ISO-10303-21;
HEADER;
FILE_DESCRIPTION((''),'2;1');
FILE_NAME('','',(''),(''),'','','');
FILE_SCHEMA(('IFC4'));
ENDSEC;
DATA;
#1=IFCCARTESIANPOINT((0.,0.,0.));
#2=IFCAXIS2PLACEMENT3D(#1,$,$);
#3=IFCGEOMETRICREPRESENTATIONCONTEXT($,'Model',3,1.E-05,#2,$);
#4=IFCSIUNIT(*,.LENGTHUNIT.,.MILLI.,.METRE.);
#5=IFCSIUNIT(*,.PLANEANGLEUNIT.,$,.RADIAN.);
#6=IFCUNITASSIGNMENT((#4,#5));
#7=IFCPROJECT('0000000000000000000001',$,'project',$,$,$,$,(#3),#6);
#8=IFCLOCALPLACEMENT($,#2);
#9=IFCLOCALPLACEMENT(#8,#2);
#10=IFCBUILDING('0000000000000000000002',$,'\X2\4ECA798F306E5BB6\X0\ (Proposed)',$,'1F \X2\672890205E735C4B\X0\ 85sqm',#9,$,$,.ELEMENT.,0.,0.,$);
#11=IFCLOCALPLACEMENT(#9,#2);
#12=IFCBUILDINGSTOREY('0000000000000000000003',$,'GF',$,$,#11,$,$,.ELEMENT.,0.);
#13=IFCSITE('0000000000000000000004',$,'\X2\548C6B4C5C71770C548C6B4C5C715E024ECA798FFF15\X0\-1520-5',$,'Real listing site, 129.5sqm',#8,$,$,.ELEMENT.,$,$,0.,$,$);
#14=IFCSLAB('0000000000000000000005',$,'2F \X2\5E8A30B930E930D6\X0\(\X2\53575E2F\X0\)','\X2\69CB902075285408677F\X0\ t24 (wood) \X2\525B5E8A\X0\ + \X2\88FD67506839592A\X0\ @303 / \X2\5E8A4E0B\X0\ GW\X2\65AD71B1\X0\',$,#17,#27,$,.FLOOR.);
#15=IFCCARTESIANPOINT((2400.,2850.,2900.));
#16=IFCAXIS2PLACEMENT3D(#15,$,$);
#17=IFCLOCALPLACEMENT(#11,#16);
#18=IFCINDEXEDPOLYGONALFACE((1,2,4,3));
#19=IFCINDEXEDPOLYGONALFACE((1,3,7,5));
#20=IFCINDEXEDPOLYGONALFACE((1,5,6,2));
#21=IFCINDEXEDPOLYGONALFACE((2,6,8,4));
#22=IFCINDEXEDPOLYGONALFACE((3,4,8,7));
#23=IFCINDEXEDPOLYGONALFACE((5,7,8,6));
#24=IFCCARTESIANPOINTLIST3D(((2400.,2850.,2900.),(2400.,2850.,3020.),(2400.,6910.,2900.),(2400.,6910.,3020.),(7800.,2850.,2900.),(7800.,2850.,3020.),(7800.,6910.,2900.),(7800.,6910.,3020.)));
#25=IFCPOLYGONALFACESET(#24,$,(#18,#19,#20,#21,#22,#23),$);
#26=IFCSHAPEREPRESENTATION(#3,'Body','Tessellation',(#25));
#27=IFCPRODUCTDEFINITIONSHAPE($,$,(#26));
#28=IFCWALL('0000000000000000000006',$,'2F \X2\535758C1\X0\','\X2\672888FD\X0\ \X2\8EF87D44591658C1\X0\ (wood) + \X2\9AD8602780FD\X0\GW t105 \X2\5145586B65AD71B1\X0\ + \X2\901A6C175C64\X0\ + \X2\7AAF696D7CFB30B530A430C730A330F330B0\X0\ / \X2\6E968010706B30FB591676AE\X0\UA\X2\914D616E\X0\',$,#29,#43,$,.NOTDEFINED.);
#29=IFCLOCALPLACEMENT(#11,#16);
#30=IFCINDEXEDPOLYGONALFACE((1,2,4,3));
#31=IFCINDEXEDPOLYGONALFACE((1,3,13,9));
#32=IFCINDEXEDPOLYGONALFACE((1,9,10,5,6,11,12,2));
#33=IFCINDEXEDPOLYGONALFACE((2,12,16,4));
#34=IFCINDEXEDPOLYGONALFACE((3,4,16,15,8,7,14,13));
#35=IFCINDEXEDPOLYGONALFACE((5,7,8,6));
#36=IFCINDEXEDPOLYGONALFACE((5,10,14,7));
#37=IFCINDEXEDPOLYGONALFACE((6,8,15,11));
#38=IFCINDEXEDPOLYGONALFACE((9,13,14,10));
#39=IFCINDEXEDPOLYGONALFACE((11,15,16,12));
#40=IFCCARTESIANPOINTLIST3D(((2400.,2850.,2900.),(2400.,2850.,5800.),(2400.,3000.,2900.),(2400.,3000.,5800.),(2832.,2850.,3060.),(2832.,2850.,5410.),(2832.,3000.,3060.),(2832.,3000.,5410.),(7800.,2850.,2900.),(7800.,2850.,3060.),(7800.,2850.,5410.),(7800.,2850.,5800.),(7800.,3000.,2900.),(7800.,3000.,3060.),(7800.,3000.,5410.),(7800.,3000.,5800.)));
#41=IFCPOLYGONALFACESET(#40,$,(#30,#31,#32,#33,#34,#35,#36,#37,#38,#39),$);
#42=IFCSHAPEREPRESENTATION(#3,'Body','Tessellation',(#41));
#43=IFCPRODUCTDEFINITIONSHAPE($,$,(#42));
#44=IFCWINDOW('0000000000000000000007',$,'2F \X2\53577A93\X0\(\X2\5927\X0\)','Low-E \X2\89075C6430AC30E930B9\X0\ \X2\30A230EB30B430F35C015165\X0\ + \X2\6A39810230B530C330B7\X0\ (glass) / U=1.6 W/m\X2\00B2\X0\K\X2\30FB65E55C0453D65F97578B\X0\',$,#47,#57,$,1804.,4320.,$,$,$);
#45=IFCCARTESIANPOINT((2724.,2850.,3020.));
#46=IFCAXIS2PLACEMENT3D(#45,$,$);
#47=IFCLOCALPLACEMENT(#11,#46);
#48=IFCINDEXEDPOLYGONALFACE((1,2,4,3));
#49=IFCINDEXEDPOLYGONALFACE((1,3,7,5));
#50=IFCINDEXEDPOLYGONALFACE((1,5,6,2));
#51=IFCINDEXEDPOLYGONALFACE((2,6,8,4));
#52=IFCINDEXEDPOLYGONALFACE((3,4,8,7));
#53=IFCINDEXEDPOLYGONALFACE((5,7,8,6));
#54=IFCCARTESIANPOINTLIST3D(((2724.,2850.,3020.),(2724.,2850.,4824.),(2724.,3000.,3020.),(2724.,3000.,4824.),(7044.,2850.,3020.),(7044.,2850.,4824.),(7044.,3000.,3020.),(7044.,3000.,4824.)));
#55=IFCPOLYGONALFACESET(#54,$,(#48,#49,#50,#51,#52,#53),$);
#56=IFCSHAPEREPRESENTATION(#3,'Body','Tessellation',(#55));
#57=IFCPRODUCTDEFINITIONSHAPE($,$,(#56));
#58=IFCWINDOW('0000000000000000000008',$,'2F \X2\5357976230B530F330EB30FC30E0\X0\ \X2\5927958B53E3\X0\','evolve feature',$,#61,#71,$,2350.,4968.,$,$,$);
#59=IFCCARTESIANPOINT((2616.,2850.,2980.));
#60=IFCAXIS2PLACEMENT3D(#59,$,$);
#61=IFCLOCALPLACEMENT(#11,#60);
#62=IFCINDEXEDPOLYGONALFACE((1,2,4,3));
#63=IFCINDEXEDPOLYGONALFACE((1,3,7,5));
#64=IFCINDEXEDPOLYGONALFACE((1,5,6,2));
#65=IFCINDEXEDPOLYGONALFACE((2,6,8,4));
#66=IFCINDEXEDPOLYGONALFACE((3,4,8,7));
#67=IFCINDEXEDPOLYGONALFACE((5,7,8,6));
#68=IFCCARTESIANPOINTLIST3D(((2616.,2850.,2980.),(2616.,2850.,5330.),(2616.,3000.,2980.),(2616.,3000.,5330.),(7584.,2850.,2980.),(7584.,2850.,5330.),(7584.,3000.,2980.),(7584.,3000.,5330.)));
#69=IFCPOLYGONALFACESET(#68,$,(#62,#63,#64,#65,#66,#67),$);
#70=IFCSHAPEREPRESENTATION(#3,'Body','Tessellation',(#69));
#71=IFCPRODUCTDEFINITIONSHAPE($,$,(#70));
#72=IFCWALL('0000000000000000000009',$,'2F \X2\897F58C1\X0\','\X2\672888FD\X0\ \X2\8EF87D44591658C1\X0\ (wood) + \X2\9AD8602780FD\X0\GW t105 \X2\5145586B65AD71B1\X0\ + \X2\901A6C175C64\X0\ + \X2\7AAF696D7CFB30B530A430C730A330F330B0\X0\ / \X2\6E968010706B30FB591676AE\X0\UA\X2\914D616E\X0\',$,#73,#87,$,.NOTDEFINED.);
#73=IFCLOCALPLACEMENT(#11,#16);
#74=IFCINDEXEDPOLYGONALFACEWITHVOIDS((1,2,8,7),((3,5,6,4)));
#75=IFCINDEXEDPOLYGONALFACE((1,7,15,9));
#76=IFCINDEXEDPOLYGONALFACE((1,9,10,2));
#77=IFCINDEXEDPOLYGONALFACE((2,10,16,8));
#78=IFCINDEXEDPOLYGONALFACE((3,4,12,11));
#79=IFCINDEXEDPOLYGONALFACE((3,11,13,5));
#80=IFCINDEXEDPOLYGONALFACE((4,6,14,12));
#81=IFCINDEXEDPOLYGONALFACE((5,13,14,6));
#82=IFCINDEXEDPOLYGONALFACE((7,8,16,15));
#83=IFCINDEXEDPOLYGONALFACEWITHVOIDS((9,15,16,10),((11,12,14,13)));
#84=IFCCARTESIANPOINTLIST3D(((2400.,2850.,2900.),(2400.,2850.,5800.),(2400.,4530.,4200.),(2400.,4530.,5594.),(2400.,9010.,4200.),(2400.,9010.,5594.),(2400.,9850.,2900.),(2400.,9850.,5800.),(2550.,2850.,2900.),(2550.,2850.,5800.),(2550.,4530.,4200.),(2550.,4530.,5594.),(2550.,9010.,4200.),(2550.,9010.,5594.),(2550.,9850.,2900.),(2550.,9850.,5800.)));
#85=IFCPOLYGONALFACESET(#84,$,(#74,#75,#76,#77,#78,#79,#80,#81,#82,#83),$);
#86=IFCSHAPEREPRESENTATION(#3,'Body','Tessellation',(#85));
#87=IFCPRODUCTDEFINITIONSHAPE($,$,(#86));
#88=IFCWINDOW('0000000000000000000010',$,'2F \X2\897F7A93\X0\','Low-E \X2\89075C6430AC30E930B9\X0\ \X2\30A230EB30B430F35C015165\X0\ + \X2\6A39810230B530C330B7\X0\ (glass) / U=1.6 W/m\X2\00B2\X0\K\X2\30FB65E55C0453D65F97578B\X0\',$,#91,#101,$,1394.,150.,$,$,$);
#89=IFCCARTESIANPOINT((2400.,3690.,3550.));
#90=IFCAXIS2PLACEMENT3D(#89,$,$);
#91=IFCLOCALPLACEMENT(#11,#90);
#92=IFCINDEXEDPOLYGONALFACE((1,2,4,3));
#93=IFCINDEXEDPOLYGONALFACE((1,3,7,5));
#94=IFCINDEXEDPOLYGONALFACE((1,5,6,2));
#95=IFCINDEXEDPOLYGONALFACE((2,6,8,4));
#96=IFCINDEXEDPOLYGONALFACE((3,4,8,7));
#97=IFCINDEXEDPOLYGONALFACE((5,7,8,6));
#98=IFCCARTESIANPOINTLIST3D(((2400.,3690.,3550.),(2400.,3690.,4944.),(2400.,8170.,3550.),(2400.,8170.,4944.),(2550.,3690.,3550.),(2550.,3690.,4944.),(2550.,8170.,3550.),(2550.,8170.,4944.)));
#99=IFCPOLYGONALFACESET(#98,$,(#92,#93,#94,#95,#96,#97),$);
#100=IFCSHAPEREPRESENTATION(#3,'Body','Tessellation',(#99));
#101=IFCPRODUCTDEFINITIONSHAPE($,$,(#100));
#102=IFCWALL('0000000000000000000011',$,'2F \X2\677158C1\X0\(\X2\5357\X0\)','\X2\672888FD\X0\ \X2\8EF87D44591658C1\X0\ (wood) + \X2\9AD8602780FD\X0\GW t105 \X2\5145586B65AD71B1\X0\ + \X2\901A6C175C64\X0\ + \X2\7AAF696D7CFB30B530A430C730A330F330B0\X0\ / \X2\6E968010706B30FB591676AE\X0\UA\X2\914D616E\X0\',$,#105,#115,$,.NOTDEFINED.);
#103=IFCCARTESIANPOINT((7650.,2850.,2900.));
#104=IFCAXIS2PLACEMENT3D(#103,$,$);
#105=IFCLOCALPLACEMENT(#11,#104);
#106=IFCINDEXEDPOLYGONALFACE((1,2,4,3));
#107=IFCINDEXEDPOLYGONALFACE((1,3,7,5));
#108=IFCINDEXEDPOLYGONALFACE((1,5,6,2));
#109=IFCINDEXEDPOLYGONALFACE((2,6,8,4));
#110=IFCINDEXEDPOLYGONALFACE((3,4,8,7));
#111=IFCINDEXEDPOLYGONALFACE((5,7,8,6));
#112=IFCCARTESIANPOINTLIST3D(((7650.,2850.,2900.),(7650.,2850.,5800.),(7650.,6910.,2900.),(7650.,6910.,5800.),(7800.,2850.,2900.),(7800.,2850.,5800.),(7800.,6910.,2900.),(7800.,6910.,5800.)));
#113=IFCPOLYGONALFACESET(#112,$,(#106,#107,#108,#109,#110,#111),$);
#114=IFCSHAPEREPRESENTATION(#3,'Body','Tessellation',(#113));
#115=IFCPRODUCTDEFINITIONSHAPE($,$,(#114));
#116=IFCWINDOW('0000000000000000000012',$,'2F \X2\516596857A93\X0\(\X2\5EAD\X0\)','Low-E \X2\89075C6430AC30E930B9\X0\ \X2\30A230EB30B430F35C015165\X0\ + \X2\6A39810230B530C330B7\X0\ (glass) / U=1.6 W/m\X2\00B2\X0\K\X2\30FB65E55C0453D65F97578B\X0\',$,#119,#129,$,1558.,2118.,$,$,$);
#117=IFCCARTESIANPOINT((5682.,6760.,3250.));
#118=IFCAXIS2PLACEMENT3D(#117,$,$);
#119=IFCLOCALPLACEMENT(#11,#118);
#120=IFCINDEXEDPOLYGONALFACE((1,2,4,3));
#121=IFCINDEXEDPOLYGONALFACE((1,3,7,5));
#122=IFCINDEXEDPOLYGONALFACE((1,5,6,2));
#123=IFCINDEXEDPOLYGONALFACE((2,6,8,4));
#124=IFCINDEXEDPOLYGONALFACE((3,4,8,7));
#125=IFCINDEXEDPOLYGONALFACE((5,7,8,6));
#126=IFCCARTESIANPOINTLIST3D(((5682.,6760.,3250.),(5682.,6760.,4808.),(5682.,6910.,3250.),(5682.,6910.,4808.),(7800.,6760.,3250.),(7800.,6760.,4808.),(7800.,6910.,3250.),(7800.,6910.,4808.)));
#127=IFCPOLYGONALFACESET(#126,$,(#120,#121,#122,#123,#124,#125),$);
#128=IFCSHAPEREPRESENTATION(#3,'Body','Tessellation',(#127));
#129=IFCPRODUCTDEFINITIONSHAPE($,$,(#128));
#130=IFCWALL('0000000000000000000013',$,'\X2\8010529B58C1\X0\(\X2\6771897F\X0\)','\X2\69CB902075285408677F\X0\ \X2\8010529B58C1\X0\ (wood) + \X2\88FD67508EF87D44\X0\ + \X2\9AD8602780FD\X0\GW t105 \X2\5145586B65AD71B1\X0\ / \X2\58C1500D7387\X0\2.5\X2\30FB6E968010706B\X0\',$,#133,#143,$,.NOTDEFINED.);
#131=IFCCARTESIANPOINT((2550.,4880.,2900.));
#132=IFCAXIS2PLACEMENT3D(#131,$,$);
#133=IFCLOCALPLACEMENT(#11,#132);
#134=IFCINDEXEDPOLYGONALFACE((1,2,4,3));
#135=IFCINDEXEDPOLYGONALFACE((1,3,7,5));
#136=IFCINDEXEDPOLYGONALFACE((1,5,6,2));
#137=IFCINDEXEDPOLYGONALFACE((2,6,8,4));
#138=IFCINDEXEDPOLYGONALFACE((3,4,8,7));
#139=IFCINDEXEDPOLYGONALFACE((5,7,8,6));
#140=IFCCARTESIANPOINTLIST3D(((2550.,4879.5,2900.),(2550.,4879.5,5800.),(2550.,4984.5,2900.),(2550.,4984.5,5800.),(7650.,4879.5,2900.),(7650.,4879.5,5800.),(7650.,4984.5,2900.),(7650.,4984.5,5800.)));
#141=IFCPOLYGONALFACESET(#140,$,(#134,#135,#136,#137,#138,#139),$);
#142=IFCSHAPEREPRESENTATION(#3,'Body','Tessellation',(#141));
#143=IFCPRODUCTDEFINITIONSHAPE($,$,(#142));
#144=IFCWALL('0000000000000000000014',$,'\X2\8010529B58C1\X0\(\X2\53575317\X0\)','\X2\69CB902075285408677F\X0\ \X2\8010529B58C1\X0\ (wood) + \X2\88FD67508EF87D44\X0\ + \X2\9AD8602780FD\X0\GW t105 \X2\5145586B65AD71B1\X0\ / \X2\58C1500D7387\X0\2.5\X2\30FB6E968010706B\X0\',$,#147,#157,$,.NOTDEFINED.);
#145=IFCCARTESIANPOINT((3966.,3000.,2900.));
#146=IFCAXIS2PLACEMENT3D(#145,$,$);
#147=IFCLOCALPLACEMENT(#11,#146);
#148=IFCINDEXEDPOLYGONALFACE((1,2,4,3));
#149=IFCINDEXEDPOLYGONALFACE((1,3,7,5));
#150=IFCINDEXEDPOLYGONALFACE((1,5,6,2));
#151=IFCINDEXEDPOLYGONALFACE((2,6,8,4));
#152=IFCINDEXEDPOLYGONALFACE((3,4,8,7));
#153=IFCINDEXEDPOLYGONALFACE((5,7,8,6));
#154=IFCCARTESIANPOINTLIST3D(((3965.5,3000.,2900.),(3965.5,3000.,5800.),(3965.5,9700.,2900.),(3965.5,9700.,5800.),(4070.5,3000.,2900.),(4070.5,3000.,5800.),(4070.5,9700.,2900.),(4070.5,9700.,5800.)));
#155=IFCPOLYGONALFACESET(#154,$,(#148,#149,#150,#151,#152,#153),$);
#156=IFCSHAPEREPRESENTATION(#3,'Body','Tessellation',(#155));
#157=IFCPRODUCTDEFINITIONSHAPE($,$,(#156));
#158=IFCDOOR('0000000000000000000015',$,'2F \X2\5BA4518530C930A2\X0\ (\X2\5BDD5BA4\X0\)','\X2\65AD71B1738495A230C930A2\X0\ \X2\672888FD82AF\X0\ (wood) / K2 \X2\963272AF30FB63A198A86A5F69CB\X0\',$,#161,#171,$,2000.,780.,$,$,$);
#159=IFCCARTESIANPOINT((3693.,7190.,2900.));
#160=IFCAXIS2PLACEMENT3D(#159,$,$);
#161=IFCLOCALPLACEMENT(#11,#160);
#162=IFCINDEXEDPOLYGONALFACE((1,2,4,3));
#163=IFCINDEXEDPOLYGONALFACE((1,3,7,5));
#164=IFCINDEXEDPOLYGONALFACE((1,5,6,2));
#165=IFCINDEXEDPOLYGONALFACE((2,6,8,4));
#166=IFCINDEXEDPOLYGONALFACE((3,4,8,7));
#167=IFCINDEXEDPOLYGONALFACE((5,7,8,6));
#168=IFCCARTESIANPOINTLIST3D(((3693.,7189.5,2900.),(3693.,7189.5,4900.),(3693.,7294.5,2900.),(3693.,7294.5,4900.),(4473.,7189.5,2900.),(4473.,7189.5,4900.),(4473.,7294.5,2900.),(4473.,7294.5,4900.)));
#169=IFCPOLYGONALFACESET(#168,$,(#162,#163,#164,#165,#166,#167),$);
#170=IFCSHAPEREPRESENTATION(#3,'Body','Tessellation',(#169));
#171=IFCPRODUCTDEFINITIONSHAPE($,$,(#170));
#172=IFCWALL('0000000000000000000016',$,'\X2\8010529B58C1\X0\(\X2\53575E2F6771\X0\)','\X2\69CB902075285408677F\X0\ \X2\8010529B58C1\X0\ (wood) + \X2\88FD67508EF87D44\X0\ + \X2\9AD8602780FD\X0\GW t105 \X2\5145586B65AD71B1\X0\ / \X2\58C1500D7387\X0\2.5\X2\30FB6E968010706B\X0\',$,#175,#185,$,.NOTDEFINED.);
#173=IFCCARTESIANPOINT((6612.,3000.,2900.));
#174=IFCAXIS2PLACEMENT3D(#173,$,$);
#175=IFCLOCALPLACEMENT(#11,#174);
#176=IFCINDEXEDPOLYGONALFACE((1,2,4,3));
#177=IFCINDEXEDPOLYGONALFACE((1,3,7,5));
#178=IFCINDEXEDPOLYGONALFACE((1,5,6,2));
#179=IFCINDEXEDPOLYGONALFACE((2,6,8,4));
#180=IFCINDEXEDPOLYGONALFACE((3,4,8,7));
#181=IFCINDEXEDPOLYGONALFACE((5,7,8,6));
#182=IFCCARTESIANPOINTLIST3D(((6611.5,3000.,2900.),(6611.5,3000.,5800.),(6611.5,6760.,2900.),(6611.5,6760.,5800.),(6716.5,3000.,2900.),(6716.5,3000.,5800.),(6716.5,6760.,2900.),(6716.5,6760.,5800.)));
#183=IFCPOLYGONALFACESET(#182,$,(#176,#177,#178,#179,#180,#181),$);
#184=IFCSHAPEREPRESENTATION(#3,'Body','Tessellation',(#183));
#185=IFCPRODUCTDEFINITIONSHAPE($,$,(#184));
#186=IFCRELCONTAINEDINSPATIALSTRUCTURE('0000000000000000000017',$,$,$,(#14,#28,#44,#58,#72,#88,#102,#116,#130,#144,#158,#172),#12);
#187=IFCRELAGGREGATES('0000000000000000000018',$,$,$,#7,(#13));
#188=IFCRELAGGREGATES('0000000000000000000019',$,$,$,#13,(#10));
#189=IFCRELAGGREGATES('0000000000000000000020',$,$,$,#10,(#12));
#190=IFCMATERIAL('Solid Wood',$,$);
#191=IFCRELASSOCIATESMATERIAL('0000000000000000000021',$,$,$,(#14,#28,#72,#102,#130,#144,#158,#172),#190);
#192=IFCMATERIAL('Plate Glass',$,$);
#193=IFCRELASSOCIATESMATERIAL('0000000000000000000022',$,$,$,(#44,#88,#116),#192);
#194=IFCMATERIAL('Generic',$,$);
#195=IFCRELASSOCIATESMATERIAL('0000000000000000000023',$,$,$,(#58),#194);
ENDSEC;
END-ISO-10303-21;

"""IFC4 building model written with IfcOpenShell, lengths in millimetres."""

from ifc_helpers import new_model, si_unit, frame, frame_2d, origin, place, context, project, spatial, rectangle, extrude, material, element, fill, save


model = new_model("IFC4")

# Units and contexts
model_context = context("Model", 3, precision=1e-05, world=origin())
ifc_project = project(units=[si_unit("LENGTHUNIT", "METRE", prefix="MILLI"), si_unit("PLANEANGLEUNIT", "RADIAN")], contexts=[model_context])

# Site, building, storey
site_placement = place(None, origin())
site = spatial("IfcSite", under=ifc_project, at=site_placement, Name="和歌山県和歌山市今福５-1520-5", ObjectType="Real listing site, 129.5sqm", CompositionType="ELEMENT", RefElevation=0.0)
building_placement = place(site_placement, origin())
building = spatial("IfcBuilding", under=site, at=building_placement, Name="今福の家 (Proposed)", ObjectType="1F 木造平屋 85sqm", CompositionType="ELEMENT", ElevationOfRefHeight=0.0, ElevationOfTerrain=0.0)
storey_placement = place(building_placement, origin())
storey = spatial("IfcBuildingStorey", under=building, at=storey_placement, Name="GF", CompositionType="ELEMENT", Elevation=0.0)

# Slab
ifc_material_1 = material(Name="Solid Wood")
slab_placement = place(storey_placement, frame((2400.0, 2850.0, 2900.0)))
element("IfcSlab", 1, at=slab_placement, inside=storey, material=ifc_material_1, Name="2F 床スラブ(南帯)", Description="構造用合板 t24 (wood) 剛床 + 製材根太 @303 / 床下 GW断熱", PredefinedType="FLOOR", context=model_context, shape_type="SweptSolid", body=[
    extrude(rectangle(XDim=5400.0, YDim=4060.0, at=frame_2d((2700.0, 2030.0))), frame((2400.0, 2850.0, 2900.0)), (0.0, 0.0, 1.0), 120.0),
])

# Wall, openings, windows
wall_1_placement = place(storey_placement, frame((2400.0, 2850.0, 2900.0)))
wall_1 = element("IfcWall", 2, at=wall_1_placement, inside=storey, material=ifc_material_1, Name="2F 南壁", Description="木製 軸組外壁 (wood) + 高性能GW t105 充填断熱 + 通気層 + 窯業系サイディング / 準耐火・外皮UA配慮", PredefinedType="NOTDEFINED", context=model_context, shape_type="SweptSolid", body=[
    extrude(rectangle(XDim=5400.0, YDim=150.0, at=frame_2d((2700.0, 75.0))), frame((2400.0, 2850.0, 2900.0)), (0.0, 0.0, 1.0), 2900.0),
])
opening_1_placement = place(storey_placement, frame((2724.0, 2850.0, 3020.0)))
opening_1 = element("IfcOpeningElement", 3, at=opening_1_placement, cuts=wall_1, PredefinedType="NOTDEFINED", context=model_context, shape_type="SweptSolid", body=[
    extrude(rectangle(XDim=4320.0, YDim=150.0, at=frame_2d((2160.0, 75.0))), frame((2724.0, 2850.0, 3020.0)), (0.0, 0.0, 1.0), 1804.0),
])
opening_2_placement = place(storey_placement, frame((2616.0, 2850.0, 2980.0)))
opening_2 = element("IfcOpeningElement", 4, at=opening_2_placement, cuts=wall_1, PredefinedType="NOTDEFINED", context=model_context, shape_type="SweptSolid", body=[
    extrude(rectangle(XDim=4968.0, YDim=150.0, at=frame_2d((2484.0, 75.0))), frame((2616.0, 2850.0, 2980.0)), (0.0, 0.0, 1.0), 2350.0),
])
ifc_material_2 = material(Name="Plate Glass")
window_1_placement = place(storey_placement, frame((2724.0, 2850.0, 3020.0)))
window_1 = element("IfcWindow", 5, at=window_1_placement, inside=storey, material=ifc_material_2, Name="2F 南窓(大)", Description="Low-E 複層ガラス アルゴン封入 + 樹脂サッシ (glass) / U=1.6 W/m²K・日射取得型", OverallHeight=1804.0, OverallWidth=4320.0, context=model_context, shape_type="SweptSolid", body=[
    extrude(rectangle(XDim=4320.0, YDim=150.0, at=frame_2d((2160.0, 75.0))), frame((2724.0, 2850.0, 3020.0)), (0.0, 0.0, 1.0), 1804.0),
])
fill(opening_1, window_1)
ifc_material_3 = material(Name="Generic")
window_2_placement = place(storey_placement, frame((2616.0, 2850.0, 2980.0)))
window_2 = element("IfcWindow", 6, at=window_2_placement, inside=storey, material=ifc_material_3, Name="2F 南面サンルーム 大開口", Description="evolve feature", OverallHeight=2350.0, OverallWidth=4968.0, context=model_context, shape_type="SweptSolid", body=[
    extrude(rectangle(XDim=4968.0, YDim=150.0, at=frame_2d((2484.0, 75.0))), frame((2616.0, 2850.0, 2980.0)), (0.0, 0.0, 1.0), 2350.0),
])
fill(opening_2, window_2)

# Walls, openings, windows
wall_2_placement = place(storey_placement, frame((2400.0, 2850.0, 2900.0)))
wall_2 = element("IfcWall", 7, at=wall_2_placement, inside=storey, material=ifc_material_1, Name="2F 西壁", Description="木製 軸組外壁 (wood) + 高性能GW t105 充填断熱 + 通気層 + 窯業系サイディング / 準耐火・外皮UA配慮", PredefinedType="NOTDEFINED", context=model_context, shape_type="SweptSolid", body=[
    extrude(rectangle(XDim=150.0, YDim=7000.0, at=frame_2d((75.0, 3500.0))), frame((2400.0, 2850.0, 2900.0)), (0.0, 0.0, 1.0), 2900.0),
])
opening_3_placement = place(storey_placement, frame((2400.0, 3690.0, 3550.0)))
opening_3 = element("IfcOpeningElement", 8, at=opening_3_placement, cuts=wall_2, PredefinedType="NOTDEFINED", context=model_context, shape_type="SweptSolid", body=[
    extrude(rectangle(XDim=150.0, YDim=4480.0, at=frame_2d((75.0, 2240.0))), frame((2400.0, 3690.0, 3550.0)), (0.0, 0.0, 1.0), 1394.0),
])
window_3_placement = place(storey_placement, frame((2400.0, 3690.0, 3550.0)))
window_3 = element("IfcWindow", 9, at=window_3_placement, inside=storey, material=ifc_material_2, Name="2F 西窓", Description="Low-E 複層ガラス アルゴン封入 + 樹脂サッシ (glass) / U=1.6 W/m²K・日射取得型", OverallHeight=1394.0, OverallWidth=150.0, context=model_context, shape_type="SweptSolid", body=[
    extrude(rectangle(XDim=150.0, YDim=4480.0, at=frame_2d((75.0, 2240.0))), frame((2400.0, 3690.0, 3550.0)), (0.0, 0.0, 1.0), 1394.0),
])
fill(opening_3, window_3)
wall_3_placement = place(storey_placement, frame((7650.0, 2850.0, 2900.0)))
wall_3 = element("IfcWall", 10, at=wall_3_placement, inside=storey, material=ifc_material_1, Name="2F 東壁(南)", Description="木製 軸組外壁 (wood) + 高性能GW t105 充填断熱 + 通気層 + 窯業系サイディング / 準耐火・外皮UA配慮", PredefinedType="NOTDEFINED", context=model_context, shape_type="SweptSolid", body=[
    extrude(rectangle(XDim=150.0, YDim=4060.0, at=frame_2d((75.0, 2030.0))), frame((7650.0, 2850.0, 2900.0)), (0.0, 0.0, 1.0), 2900.0),
])
opening_4_placement = place(storey_placement, frame((5682.0, 6760.0, 3250.0)))
opening_4 = element("IfcOpeningElement", 11, at=opening_4_placement, cuts=wall_3, PredefinedType="NOTDEFINED", context=model_context, shape_type="SweptSolid", body=[
    extrude(rectangle(XDim=2118.0, YDim=150.0, at=frame_2d((1059.0, 75.0))), frame((5682.0, 6760.0, 3250.0)), (0.0, 0.0, 1.0), 1558.0),
])
window_4_placement = place(storey_placement, frame((5682.0, 6760.0, 3250.0)))
window_4 = element("IfcWindow", 12, at=window_4_placement, inside=storey, material=ifc_material_2, Name="2F 入隅窓(庭)", Description="Low-E 複層ガラス アルゴン封入 + 樹脂サッシ (glass) / U=1.6 W/m²K・日射取得型", OverallHeight=1558.0, OverallWidth=2118.0, context=model_context, shape_type="SweptSolid", body=[
    extrude(rectangle(XDim=2118.0, YDim=150.0, at=frame_2d((1059.0, 75.0))), frame((5682.0, 6760.0, 3250.0)), (0.0, 0.0, 1.0), 1558.0),
])
fill(opening_4, window_4)

# Wall
wall_4_placement = place(storey_placement, frame((2550.0, 4880.0, 2900.0)))
element("IfcWall", 13, at=wall_4_placement, inside=storey, material=ifc_material_1, Name="耐力壁(東西)", Description="構造用合板 耐力壁 (wood) + 製材軸組 + 高性能GW t105 充填断熱 / 壁倍率2.5・準耐火", PredefinedType="NOTDEFINED", context=model_context, shape_type="SweptSolid", body=[
    extrude(rectangle(XDim=5100.0, YDim=105.0, at=frame_2d((2550.0, 52.0))), frame((2550.0, 4880.0, 2900.0)), (0.0, 0.0, 1.0), 2900.0),
])

# Wall, opening, door
wall_5_placement = place(storey_placement, frame((3966.0, 3000.0, 2900.0)))
wall_5 = element("IfcWall", 14, at=wall_5_placement, inside=storey, material=ifc_material_1, Name="耐力壁(南北)", Description="構造用合板 耐力壁 (wood) + 製材軸組 + 高性能GW t105 充填断熱 / 壁倍率2.5・準耐火", PredefinedType="NOTDEFINED", context=model_context, shape_type="SweptSolid", body=[
    extrude(rectangle(XDim=105.0, YDim=6700.0, at=frame_2d((52.0, 3350.0))), frame((3966.0, 3000.0, 2900.0)), (0.0, 0.0, 1.0), 2900.0),
])
opening_5_placement = place(storey_placement, frame((3693.0, 7190.0, 2900.0)))
opening_5 = element("IfcOpeningElement", 15, at=opening_5_placement, cuts=wall_5, PredefinedType="NOTDEFINED", context=model_context, shape_type="SweptSolid", body=[
    extrude(rectangle(XDim=780.0, YDim=105.0, at=frame_2d((390.0, 52.0))), frame((3693.0, 7190.0, 2900.0)), (0.0, 0.0, 1.0), 2000.0),
])
door_placement = place(storey_placement, frame((3693.0, 7190.0, 2900.0)))
door = element("IfcDoor", 16, at=door_placement, inside=storey, material=ifc_material_1, Name="2F 室内ドア (寝室)", Description="断熱玄関ドア 木製芯 (wood) / K2 防犯・採風機構", OverallHeight=2000.0, OverallWidth=780.0, context=model_context, shape_type="SweptSolid", body=[
    extrude(rectangle(XDim=780.0, YDim=105.0, at=frame_2d((390.0, 52.0))), frame((3693.0, 7190.0, 2900.0)), (0.0, 0.0, 1.0), 2000.0),
])
fill(opening_5, door)

# Wall
wall_6_placement = place(storey_placement, frame((6612.0, 3000.0, 2900.0)))
element("IfcWall", 17, at=wall_6_placement, inside=storey, material=ifc_material_1, Name="耐力壁(南帯東)", Description="構造用合板 耐力壁 (wood) + 製材軸組 + 高性能GW t105 充填断熱 / 壁倍率2.5・準耐火", PredefinedType="NOTDEFINED", context=model_context, shape_type="SweptSolid", body=[
    extrude(rectangle(XDim=105.0, YDim=3760.0, at=frame_2d((52.0, 1880.0))), frame((6612.0, 3000.0, 2900.0)), (0.0, 0.0, 1.0), 2900.0),
])

save(model, "model.ifc")
